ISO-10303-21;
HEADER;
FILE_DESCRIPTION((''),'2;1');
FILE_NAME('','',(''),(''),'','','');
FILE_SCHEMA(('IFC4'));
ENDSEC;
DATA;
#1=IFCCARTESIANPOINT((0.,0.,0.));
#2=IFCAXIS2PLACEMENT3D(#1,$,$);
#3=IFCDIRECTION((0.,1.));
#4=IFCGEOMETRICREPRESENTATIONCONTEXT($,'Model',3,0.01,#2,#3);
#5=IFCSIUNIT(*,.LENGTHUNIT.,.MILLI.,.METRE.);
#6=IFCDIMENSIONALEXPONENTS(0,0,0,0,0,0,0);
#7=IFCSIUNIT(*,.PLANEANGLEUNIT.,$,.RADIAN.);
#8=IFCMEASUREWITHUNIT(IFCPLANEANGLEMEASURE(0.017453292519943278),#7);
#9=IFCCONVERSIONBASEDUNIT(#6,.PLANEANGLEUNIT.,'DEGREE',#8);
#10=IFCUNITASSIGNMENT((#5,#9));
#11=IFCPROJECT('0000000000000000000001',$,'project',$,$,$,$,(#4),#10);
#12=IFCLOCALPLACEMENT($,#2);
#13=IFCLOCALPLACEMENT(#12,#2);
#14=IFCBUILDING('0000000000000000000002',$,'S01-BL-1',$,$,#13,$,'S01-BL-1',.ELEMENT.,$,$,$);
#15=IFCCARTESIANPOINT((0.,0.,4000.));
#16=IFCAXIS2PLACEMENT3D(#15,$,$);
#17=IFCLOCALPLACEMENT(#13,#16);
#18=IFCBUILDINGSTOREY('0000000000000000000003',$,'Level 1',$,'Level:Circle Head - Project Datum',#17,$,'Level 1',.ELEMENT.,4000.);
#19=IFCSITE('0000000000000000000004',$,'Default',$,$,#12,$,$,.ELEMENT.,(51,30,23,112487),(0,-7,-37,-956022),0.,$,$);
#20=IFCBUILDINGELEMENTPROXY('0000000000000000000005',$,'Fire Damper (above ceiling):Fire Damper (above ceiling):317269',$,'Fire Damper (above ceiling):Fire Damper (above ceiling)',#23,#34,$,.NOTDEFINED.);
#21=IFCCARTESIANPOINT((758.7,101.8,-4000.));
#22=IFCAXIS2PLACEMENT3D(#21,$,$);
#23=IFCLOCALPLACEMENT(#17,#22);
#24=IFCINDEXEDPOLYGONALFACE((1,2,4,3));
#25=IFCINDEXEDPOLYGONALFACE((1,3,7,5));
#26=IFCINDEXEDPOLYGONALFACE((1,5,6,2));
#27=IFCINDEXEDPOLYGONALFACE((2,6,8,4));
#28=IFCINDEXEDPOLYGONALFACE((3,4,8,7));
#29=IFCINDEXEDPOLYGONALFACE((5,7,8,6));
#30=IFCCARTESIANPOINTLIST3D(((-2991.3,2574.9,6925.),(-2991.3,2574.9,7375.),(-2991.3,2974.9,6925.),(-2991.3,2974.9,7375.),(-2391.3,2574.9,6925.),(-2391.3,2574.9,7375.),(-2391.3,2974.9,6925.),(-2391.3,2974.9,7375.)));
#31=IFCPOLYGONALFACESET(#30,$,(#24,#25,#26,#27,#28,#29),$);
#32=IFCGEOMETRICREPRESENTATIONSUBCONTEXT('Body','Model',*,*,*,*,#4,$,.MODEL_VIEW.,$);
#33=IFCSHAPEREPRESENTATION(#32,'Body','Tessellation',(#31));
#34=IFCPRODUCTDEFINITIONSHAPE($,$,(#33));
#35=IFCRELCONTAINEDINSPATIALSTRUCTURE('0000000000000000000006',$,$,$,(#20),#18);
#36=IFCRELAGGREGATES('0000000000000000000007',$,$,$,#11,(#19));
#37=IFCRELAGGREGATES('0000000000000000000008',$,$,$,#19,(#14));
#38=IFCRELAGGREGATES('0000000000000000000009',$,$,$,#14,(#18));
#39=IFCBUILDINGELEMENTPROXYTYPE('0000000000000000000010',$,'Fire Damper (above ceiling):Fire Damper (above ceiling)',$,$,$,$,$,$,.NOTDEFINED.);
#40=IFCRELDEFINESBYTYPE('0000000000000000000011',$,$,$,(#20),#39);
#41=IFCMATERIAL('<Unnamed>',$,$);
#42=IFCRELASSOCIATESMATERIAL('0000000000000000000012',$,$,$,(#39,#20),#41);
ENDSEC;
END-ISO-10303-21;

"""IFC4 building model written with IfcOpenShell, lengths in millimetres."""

from ifc_helpers import new_model, entity, si_unit, converted_unit, direction, frame, origin, place, context, subcontext, project, spatial, indexed_curve, outline, extrude, source, transform, mapped, material, type_object, type_shapes, element, save


model = new_model("IFC4")

# Units and contexts
model_context = context("Model", 3, precision=0.01, world=origin(), true_north=direction((0.0, 1.0)))
body_context = subcontext(model_context, "Body", "Model", "MODEL_VIEW")
ifc_project = project(units=[si_unit("LENGTHUNIT", "METRE", prefix="MILLI"), converted_unit("PLANEANGLEUNIT", "DEGREE", entity("IfcPlaneAngleMeasure", 0.017453292519943278), si_unit("PLANEANGLEUNIT", "RADIAN"), dimensions=[0, 0, 0, 0, 0, 0, 0])], contexts=[model_context])

# Site, building, storey
site_placement = place(None, origin())
site = spatial("IfcSite", under=ifc_project, at=site_placement, Name="Default", CompositionType="ELEMENT", RefLatitude=(51, 30, 23, 112487), RefLongitude=(0, -7, -37, -956022), RefElevation=0.0)
building_placement = place(site_placement, origin())
building = spatial("IfcBuilding", under=site, at=building_placement, Name="S01-BL-1", LongName="S01-BL-1", CompositionType="ELEMENT")
storey_placement = place(building_placement, frame((0.0, 0.0, 4000.0)))
storey = spatial("IfcBuildingStorey", under=building, at=storey_placement, Name="Level 1", ObjectType="Level:Circle Head - Project Datum", LongName="Level 1", CompositionType="ELEMENT", Elevation=4000.0)

# Building element proxy
ifc_material_1 = material(Name="<Unnamed>")
building_element_proxy_type_1 = type_object("IfcBuildingElementProxyType", Name="Fire Damper (above ceiling):Fire Damper (above ceiling)", PredefinedType="NOTDEFINED", material=ifc_material_1)
shared_shape_1 = source(origin(), body_context, "Body", "SweptSolid", [
    extrude(outline(indexed_curve([(-300.0, -200.0), (300.0, -200.0), (300.0, 200.0), (-300.0, 200.0), (-300.0, -200.0)], self_intersect=False)), frame((-2691.3, 2774.9, 6925.0), z_axis=(0.0, 0.0, 1.0), x_axis=(-1.0, 0.0, 0.0)), (0.0, 0.0, 1.0), 450.0),
])
type_shapes(building_element_proxy_type_1, [shared_shape_1])
proxy_1_placement = place(storey_placement, frame((758.7, 101.8, -4000.0)))
element("IfcBuildingElementProxy", 1, at=proxy_1_placement, inside=storey, type_object=building_element_proxy_type_1, material=ifc_material_1, Name="Fire Damper (above ceiling):Fire Damper (above ceiling):317269", ObjectType="Fire Damper (above ceiling):Fire Damper (above ceiling)", PredefinedType="NOTDEFINED", context=body_context, shape_type="MappedRepresentation", body=[
    mapped(shared_shape_1, transform((0.0, 0.0, 0.0), scale=1.0)),
])

save(model, "model.ifc")
